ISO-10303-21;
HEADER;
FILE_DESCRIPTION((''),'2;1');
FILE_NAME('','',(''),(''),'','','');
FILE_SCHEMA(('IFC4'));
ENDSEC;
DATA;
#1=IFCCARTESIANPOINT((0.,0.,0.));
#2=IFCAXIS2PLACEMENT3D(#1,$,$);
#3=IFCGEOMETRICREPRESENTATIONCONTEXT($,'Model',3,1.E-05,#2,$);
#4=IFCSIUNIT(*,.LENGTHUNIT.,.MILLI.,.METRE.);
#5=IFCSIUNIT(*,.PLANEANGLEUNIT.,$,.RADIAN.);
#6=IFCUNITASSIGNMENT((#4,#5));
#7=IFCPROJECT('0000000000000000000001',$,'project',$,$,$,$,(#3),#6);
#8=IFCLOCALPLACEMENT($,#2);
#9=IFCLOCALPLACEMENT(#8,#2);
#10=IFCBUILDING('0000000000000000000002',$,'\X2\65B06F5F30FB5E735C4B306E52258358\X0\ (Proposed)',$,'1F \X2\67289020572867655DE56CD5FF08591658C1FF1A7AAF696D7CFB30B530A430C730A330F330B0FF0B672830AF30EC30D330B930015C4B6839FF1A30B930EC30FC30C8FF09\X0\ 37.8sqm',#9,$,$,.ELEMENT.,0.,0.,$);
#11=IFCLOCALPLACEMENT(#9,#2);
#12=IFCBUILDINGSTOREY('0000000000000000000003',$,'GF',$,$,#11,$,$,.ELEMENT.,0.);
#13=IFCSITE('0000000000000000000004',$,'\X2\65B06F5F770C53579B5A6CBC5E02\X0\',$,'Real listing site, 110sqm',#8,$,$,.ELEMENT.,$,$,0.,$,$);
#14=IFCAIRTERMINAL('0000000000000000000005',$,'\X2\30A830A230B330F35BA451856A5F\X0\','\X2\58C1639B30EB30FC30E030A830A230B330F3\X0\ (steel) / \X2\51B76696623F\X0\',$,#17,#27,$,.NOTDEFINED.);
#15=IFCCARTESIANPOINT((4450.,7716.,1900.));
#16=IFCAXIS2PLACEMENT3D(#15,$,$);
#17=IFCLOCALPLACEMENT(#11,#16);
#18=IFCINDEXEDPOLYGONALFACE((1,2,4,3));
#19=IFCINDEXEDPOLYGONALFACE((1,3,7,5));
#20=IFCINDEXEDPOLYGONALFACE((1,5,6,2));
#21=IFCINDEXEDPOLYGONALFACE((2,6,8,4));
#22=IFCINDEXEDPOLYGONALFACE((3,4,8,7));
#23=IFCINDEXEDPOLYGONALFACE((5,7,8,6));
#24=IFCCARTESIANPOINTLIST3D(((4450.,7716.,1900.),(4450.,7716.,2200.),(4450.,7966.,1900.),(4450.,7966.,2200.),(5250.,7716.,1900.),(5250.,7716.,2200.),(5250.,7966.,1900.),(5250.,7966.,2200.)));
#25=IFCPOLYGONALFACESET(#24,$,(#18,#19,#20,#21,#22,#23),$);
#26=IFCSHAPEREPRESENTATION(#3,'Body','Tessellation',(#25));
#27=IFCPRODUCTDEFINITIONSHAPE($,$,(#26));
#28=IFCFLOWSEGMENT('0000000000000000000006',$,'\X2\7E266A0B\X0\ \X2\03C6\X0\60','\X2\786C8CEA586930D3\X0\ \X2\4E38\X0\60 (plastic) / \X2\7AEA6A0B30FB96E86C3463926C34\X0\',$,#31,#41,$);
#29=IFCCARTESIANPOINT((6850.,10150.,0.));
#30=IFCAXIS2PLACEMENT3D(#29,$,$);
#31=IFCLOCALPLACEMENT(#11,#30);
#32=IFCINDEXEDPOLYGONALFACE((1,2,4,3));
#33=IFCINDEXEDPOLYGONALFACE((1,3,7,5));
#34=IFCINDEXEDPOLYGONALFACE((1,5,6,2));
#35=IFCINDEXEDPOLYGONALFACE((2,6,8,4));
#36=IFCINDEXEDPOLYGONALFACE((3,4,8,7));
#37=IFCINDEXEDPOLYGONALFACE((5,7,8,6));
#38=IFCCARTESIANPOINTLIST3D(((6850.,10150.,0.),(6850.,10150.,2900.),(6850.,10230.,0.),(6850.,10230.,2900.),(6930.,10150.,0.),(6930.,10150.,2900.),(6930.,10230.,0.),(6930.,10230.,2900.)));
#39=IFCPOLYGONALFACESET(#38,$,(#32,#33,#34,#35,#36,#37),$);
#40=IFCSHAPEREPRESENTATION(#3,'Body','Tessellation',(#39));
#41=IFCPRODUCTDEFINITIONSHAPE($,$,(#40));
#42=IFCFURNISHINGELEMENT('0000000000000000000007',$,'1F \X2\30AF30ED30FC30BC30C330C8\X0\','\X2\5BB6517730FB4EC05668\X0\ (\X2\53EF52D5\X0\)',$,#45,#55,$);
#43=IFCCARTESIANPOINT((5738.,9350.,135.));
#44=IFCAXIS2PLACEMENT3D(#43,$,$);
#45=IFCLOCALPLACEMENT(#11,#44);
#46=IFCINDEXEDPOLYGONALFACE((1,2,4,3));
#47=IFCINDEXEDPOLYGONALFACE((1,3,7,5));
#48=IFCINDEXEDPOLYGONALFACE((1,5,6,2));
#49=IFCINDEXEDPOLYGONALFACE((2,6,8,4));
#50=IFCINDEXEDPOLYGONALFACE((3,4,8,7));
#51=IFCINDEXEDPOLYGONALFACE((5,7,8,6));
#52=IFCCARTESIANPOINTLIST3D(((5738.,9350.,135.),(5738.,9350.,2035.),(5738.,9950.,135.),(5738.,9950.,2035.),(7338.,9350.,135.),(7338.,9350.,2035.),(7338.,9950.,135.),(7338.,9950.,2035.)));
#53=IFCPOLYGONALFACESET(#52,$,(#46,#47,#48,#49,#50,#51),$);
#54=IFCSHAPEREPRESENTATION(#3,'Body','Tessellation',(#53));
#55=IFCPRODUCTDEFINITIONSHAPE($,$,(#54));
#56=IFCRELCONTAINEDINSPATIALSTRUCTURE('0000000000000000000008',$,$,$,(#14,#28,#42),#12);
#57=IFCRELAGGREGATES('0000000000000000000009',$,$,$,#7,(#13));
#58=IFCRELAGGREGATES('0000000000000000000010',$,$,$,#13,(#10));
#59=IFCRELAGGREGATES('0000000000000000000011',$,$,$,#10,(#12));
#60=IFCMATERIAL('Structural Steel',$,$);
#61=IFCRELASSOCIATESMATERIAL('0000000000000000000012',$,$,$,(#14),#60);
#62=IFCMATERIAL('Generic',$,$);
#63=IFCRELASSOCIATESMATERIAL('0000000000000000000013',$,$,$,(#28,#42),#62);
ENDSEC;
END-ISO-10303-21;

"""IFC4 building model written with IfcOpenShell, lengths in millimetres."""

from ifc_helpers import new_model, si_unit, frame, frame_2d, origin, place, context, project, spatial, rectangle, extrude, material, element, save


model = new_model("IFC4")

# Units and contexts
model_context = context("Model", 3, precision=1e-05, world=origin())
ifc_project = project(units=[si_unit("LENGTHUNIT", "METRE", prefix="MILLI"), si_unit("PLANEANGLEUNIT", "RADIAN")], contexts=[model_context])

# Site, building, storey
site_placement = place(None, origin())
site = spatial("IfcSite", under=ifc_project, at=site_placement, Name="新潟県南魚沼市", ObjectType="Real listing site, 110sqm", CompositionType="ELEMENT", RefElevation=0.0)
building_placement = place(site_placement, origin())
building = spatial("IfcBuilding", under=site, at=building_placement, Name="新潟・平屋の別荘 (Proposed)", ObjectType="1F 木造在来工法（外壁：窯業系サイディング＋木クレビス、屋根：スレート） 37.8sqm", CompositionType="ELEMENT", ElevationOfRefHeight=0.0, ElevationOfTerrain=0.0)
storey_placement = place(building_placement, origin())
storey = spatial("IfcBuildingStorey", under=building, at=storey_placement, Name="GF", CompositionType="ELEMENT", Elevation=0.0)

# Shared definitions
ifc_material_1 = material(Name="Structural Steel")

# Shared definitions
ifc_material_2 = material(Name="Generic")

# Air terminal
air_terminal_placement = place(storey_placement, frame((4450.0, 7716.0, 1900.0)))
element("IfcAirTerminal", 1, at=air_terminal_placement, inside=storey, material=ifc_material_1, Name="エアコン室内機", Description="壁掛ルームエアコン (steel) / 冷暖房", PredefinedType="NOTDEFINED", context=model_context, shape_type="SweptSolid", body=[
    extrude(rectangle(XDim=800.0, YDim=250.0, at=frame_2d((400.0, 125.0))), frame((4450.0, 7716.0, 1900.0)), (0.0, 0.0, 1.0), 300.0),
])

# Flow segment
flow_segment_placement = place(storey_placement, frame((6850.0, 10150.0, 0.0)))
element("IfcFlowSegment", 2, at=flow_segment_placement, inside=storey, material=ifc_material_2, Name="縦樋 φ60", Description="硬質塩ビ 丸60 (plastic) / 竪樋・雨水排水", context=model_context, shape_type="SweptSolid", body=[
    extrude(rectangle(XDim=80.0, YDim=80.0, at=frame_2d((40.0, 40.0))), frame((6850.0, 10150.0, 0.0)), (0.0, 0.0, 1.0), 2900.0),
])

# Furnishing element
furnishing_placement = place(storey_placement, frame((5738.0, 9350.0, 135.0)))
element("IfcFurnishingElement", 3, at=furnishing_placement, inside=storey, material=ifc_material_2, Name="1F クローゼット", Description="家具・什器 (可動)", context=model_context, shape_type="SweptSolid", body=[
    extrude(rectangle(XDim=1600.0, YDim=600.0, at=frame_2d((800.0, 300.0))), frame((5738.0, 9350.0, 135.0)), (0.0, 0.0, 1.0), 1900.0),
])

save(model, "model.ifc")
